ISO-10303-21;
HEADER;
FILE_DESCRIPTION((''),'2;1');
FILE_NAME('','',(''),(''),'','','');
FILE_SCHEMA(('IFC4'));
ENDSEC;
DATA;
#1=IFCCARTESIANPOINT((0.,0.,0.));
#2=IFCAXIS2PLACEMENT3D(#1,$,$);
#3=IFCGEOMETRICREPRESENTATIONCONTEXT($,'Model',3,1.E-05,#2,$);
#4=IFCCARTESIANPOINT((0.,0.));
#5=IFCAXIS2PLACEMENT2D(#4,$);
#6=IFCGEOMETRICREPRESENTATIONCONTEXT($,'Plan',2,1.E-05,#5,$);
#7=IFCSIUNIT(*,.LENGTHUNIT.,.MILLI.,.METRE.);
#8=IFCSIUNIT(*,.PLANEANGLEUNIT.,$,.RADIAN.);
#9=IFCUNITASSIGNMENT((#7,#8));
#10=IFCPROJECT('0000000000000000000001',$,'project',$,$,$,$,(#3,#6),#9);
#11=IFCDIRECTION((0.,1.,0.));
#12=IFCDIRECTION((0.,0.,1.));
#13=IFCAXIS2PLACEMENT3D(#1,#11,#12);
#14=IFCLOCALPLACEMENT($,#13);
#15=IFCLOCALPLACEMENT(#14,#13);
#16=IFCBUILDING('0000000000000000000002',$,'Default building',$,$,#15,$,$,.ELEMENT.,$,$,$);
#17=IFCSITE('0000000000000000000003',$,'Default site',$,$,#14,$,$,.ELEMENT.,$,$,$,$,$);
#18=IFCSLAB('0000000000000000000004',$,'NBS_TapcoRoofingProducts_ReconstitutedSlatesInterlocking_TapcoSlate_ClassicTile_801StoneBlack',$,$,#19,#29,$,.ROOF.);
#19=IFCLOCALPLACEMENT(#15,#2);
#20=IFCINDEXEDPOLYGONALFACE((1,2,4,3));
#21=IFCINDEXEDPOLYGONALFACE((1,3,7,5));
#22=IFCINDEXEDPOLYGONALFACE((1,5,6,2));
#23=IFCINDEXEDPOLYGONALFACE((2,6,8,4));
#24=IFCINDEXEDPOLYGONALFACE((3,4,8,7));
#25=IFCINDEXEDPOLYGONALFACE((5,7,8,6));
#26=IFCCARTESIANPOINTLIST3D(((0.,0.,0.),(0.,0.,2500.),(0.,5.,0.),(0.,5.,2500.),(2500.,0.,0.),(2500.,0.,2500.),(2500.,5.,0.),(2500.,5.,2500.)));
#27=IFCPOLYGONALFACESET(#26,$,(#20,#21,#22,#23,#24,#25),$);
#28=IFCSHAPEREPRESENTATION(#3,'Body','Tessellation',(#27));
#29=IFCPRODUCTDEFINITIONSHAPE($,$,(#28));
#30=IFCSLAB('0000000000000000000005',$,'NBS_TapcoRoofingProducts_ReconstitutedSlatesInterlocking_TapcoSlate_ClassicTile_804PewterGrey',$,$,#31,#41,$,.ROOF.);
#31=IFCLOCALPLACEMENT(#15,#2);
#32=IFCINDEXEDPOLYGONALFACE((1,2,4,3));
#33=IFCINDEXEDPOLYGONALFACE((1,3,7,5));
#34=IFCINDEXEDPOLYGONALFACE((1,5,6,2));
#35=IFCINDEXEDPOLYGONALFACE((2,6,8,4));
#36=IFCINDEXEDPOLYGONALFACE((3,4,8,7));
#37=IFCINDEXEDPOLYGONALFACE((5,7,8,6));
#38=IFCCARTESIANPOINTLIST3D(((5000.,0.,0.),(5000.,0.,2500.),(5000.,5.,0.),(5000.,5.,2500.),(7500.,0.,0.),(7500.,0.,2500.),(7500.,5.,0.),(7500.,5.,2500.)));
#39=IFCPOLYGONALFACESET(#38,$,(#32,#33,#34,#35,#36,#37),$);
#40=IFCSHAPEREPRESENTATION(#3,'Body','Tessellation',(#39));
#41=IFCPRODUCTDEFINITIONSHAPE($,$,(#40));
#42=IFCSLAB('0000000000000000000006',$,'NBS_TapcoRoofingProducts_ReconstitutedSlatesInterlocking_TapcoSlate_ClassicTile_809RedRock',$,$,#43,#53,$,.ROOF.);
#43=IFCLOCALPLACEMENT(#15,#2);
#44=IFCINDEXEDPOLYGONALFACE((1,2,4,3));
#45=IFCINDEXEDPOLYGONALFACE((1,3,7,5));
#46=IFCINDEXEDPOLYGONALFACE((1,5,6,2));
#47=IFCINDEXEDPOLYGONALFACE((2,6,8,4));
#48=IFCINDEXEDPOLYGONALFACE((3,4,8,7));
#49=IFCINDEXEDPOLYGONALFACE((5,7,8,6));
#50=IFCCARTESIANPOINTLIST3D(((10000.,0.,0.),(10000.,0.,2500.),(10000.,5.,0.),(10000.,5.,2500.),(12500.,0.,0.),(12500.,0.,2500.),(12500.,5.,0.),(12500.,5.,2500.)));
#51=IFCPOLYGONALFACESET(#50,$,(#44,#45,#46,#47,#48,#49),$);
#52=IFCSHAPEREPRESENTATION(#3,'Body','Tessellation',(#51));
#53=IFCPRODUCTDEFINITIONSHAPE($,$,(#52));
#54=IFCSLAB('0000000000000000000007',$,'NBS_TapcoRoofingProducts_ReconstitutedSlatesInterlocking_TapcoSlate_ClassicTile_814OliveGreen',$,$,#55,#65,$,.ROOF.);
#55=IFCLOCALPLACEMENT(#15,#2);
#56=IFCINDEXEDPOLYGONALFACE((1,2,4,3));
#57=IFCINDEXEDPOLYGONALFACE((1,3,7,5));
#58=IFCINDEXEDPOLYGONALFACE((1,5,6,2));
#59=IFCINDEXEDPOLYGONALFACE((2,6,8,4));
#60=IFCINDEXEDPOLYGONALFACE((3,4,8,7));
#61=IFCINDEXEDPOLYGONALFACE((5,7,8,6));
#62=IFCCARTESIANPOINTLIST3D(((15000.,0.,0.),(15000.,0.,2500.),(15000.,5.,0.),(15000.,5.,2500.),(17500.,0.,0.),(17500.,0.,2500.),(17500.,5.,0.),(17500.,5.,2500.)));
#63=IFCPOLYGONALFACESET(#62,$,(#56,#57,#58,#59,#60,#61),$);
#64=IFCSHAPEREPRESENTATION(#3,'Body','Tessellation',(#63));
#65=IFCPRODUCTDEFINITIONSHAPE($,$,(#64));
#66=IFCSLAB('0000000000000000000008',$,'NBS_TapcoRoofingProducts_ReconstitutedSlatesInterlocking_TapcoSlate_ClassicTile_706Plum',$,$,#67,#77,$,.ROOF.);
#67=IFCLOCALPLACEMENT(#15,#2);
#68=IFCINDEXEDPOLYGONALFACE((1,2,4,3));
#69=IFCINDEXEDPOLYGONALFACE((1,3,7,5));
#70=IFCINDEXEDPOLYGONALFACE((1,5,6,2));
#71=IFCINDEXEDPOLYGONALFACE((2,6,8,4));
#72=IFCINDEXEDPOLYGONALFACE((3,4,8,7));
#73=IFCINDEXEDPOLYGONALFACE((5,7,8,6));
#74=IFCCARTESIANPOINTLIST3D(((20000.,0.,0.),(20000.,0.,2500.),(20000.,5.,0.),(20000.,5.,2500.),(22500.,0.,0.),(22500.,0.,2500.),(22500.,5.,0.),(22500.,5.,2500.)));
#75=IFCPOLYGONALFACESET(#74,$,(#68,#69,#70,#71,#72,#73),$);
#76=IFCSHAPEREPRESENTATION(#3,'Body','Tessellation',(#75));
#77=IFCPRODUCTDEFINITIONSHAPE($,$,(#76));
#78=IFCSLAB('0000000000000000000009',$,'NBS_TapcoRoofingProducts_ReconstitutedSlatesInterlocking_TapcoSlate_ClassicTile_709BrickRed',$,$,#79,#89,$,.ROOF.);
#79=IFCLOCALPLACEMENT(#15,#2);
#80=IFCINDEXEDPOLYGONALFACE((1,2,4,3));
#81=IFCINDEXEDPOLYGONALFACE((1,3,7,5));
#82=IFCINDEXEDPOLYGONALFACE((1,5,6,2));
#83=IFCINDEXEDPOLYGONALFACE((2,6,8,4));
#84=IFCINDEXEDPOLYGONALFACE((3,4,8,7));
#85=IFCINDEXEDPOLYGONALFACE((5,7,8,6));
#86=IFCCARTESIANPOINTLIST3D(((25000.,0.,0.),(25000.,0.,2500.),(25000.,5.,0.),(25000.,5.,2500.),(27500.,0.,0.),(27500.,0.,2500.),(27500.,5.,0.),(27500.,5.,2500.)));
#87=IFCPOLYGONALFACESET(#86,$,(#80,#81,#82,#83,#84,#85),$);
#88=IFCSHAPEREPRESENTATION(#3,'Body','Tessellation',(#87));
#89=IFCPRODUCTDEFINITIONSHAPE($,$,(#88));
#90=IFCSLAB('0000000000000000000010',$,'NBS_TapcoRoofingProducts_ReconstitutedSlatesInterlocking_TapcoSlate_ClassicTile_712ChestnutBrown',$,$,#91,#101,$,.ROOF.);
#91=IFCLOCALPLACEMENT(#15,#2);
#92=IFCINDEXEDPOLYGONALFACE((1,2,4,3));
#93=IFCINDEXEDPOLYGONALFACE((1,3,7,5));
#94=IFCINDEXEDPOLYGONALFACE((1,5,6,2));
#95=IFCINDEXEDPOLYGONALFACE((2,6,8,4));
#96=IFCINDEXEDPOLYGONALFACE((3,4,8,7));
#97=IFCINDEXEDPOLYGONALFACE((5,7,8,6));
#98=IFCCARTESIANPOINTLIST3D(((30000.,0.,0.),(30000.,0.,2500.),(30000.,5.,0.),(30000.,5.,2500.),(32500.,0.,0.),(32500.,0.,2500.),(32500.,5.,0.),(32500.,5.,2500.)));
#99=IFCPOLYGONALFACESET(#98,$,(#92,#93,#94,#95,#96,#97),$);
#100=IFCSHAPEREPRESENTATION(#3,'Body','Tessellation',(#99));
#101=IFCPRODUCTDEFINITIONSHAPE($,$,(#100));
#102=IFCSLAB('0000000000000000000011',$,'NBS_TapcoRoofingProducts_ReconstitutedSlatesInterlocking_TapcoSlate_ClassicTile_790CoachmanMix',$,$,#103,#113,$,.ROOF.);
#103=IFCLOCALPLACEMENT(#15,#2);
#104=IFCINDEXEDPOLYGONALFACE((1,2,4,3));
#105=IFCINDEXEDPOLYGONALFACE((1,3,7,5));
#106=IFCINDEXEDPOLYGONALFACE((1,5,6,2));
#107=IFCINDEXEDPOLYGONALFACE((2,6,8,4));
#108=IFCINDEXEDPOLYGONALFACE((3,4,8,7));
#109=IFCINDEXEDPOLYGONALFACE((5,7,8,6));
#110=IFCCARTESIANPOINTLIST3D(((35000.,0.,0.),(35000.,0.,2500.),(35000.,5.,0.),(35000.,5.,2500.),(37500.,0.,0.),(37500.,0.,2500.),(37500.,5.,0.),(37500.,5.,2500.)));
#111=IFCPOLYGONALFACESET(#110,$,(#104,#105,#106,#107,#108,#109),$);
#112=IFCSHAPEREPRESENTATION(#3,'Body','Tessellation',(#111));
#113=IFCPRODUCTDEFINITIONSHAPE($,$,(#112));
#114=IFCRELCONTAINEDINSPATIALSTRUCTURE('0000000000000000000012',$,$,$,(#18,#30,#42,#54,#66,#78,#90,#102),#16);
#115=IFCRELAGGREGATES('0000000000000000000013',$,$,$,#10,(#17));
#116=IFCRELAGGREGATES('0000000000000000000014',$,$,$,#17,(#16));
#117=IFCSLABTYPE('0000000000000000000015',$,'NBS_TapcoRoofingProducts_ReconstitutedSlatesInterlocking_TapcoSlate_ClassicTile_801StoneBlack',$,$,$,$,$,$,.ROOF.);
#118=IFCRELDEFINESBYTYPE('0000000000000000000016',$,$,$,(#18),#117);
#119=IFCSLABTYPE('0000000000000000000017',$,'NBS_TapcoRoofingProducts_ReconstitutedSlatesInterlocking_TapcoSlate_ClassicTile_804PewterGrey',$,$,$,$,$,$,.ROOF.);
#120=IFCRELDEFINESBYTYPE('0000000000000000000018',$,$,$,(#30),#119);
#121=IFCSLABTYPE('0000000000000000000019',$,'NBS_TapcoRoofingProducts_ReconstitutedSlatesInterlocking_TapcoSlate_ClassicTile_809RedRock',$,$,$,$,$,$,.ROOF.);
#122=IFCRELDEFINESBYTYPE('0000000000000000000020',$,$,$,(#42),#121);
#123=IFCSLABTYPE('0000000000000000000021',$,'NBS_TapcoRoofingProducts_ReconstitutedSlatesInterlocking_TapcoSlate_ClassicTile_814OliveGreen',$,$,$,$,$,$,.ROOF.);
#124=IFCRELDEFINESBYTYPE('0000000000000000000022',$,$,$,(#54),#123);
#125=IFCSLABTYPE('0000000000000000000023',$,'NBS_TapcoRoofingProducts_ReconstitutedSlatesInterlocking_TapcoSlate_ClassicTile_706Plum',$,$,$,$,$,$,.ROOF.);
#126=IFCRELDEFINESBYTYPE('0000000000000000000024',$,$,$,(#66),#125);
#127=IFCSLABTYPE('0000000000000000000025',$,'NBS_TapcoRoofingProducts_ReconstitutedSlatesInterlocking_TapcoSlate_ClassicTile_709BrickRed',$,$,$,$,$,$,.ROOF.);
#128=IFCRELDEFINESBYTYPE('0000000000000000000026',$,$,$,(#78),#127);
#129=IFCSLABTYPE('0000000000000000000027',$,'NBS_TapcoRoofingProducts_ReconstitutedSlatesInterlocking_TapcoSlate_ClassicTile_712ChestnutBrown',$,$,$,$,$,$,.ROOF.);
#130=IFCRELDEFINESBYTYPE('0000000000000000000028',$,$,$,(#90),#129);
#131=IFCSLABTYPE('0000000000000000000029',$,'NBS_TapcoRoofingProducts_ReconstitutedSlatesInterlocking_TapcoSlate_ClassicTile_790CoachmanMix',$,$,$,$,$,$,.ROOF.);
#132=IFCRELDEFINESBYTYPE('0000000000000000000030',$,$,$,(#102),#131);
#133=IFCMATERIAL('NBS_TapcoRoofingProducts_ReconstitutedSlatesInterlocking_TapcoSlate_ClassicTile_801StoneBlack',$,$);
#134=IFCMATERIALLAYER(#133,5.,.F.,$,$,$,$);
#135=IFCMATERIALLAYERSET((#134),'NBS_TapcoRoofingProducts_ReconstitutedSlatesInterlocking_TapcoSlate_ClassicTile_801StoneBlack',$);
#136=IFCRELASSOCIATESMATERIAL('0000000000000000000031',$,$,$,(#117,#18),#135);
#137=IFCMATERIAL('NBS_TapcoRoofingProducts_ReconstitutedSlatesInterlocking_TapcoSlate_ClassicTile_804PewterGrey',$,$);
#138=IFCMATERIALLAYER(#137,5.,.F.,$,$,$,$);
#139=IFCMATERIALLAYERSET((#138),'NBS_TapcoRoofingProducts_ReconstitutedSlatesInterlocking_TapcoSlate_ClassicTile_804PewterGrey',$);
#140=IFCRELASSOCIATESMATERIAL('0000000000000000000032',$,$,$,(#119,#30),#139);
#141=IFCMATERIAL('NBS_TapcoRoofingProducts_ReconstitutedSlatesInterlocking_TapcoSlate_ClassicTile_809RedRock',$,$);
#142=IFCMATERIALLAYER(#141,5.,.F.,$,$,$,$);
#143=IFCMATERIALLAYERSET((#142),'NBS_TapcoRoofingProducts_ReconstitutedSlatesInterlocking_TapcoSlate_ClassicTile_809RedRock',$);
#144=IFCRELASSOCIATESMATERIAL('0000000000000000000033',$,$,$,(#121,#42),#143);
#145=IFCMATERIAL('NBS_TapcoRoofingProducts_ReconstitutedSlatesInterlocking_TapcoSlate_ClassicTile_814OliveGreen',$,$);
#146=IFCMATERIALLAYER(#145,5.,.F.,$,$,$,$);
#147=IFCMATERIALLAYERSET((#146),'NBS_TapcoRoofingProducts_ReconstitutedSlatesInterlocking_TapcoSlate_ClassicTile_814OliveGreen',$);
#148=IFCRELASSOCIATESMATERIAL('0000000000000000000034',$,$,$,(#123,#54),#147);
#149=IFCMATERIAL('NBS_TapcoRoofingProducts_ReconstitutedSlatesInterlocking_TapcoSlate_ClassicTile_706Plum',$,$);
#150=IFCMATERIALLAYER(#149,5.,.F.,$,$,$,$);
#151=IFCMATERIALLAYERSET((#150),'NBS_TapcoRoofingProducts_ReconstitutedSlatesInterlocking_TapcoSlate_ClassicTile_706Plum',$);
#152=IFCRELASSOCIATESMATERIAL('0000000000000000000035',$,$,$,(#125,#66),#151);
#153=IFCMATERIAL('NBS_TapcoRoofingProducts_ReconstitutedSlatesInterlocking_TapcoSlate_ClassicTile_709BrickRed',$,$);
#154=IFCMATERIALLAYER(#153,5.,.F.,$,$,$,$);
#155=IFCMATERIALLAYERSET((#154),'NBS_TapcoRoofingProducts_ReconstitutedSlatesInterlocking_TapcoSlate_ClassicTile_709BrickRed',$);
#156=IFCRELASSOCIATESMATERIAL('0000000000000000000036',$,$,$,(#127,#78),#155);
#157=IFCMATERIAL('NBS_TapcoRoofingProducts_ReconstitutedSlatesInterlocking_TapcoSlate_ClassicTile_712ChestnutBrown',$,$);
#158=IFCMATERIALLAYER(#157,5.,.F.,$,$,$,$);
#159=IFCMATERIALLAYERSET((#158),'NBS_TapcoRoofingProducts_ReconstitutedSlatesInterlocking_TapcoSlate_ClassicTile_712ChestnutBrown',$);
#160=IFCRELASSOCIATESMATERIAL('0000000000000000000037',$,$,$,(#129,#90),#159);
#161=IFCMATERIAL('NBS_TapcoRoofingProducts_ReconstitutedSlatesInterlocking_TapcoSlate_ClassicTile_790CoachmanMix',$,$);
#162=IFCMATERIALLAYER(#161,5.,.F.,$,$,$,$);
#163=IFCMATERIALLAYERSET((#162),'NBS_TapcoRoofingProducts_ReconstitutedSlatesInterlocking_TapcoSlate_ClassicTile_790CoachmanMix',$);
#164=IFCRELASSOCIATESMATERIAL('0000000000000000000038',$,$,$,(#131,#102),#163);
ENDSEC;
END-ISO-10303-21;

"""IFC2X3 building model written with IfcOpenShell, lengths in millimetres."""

from ifc_helpers import new_model, si_unit, frame, frame_2d, origin, origin_with_axes, origin_2d, place, context, project, spatial, rectangle, extrude, material, layer, layer_set, layer_usage, type_object, element, save


model = new_model("IFC2X3")

# Units and contexts
model_context = context("Model", 3, precision=1e-05, world=origin())
plan_context = context("Plan", 2, precision=1e-05, world=origin_2d())
ifc_project = project(units=[si_unit("LENGTHUNIT", "METRE", prefix="MILLI"), si_unit("PLANEANGLEUNIT", "RADIAN")], contexts=[model_context, plan_context])

# Site, building
site_placement = place(None, frame((0.0, 0.0, 0.0), z_axis=(0.0, 1.0, 0.0), x_axis=(0.0, 0.0, 1.0)))
site = spatial("IfcSite", under=ifc_project, at=site_placement, Name="Default site", CompositionType="ELEMENT")
building_placement = place(site_placement, frame((0.0, 0.0, 0.0), z_axis=(0.0, 1.0, 0.0), x_axis=(0.0, 0.0, 1.0)))
building = spatial("IfcBuilding", under=site, at=building_placement, Name="Default building", CompositionType="ELEMENT")

# Slabs
ifc_material_1 = material(Name="NBS_TapcoRoofingProducts_ReconstitutedSlatesInterlocking_TapcoSlate_ClassicTile_801StoneBlack")
ifc_layer_1 = layer(ifc_material_1, 5.0, ventilated=False)
ifc_layer_set_1 = layer_set([ifc_layer_1], Name="NBS_TapcoRoofingProducts_ReconstitutedSlatesInterlocking_TapcoSlate_ClassicTile_801StoneBlack")
ifc_layer_usage_1 = layer_usage(ifc_layer_set_1, "AXIS3", "NEGATIVE", 0.0)
slab_type_1 = type_object("IfcSlabType", Name="NBS_TapcoRoofingProducts_ReconstitutedSlatesInterlocking_TapcoSlate_ClassicTile_801StoneBlack", PredefinedType="ROOF", material=ifc_layer_set_1)
slab_1_placement = place(None, origin())
element("IfcSlab", 1, at=slab_1_placement, inside=building, type_object=slab_type_1, material=ifc_layer_usage_1, Name="NBS_TapcoRoofingProducts_ReconstitutedSlatesInterlocking_TapcoSlate_ClassicTile_801StoneBlack", PredefinedType="ROOF", context=model_context, shape_type="SweptSolid", body=[
    extrude(rectangle(XDim=2500.0, YDim=2500.0, at=frame_2d((1250.0, 1250.0))), origin_with_axes(), (0.0, 0.0, 1.0), 5.0),
])
ifc_material_2 = material(Name="NBS_TapcoRoofingProducts_ReconstitutedSlatesInterlocking_TapcoSlate_ClassicTile_804PewterGrey")
ifc_layer_2 = layer(ifc_material_2, 5.0, ventilated=False)
ifc_layer_set_2 = layer_set([ifc_layer_2], Name="NBS_TapcoRoofingProducts_ReconstitutedSlatesInterlocking_TapcoSlate_ClassicTile_804PewterGrey")
ifc_layer_usage_2 = layer_usage(ifc_layer_set_2, "AXIS3", "NEGATIVE", 0.0)
slab_type_2 = type_object("IfcSlabType", Name="NBS_TapcoRoofingProducts_ReconstitutedSlatesInterlocking_TapcoSlate_ClassicTile_804PewterGrey", PredefinedType="ROOF", material=ifc_layer_set_2)
slab_2_placement = place(None, frame((0.0, 5000.0, 0.0)))
element("IfcSlab", 2, at=slab_2_placement, inside=building, type_object=slab_type_2, material=ifc_layer_usage_2, Name="NBS_TapcoRoofingProducts_ReconstitutedSlatesInterlocking_TapcoSlate_ClassicTile_804PewterGrey", PredefinedType="ROOF", context=model_context, shape_type="SweptSolid", body=[
    extrude(rectangle(XDim=2500.0, YDim=2500.0, at=frame_2d((1250.0, 1250.0))), origin_with_axes(), (0.0, 0.0, 1.0), 5.0),
])
ifc_material_3 = material(Name="NBS_TapcoRoofingProducts_ReconstitutedSlatesInterlocking_TapcoSlate_ClassicTile_809RedRock")
ifc_layer_3 = layer(ifc_material_3, 5.0, ventilated=False)
ifc_layer_set_3 = layer_set([ifc_layer_3], Name="NBS_TapcoRoofingProducts_ReconstitutedSlatesInterlocking_TapcoSlate_ClassicTile_809RedRock")
ifc_layer_usage_3 = layer_usage(ifc_layer_set_3, "AXIS3", "NEGATIVE", 0.0)
slab_type_3 = type_object("IfcSlabType", Name="NBS_TapcoRoofingProducts_ReconstitutedSlatesInterlocking_TapcoSlate_ClassicTile_809RedRock", PredefinedType="ROOF", material=ifc_layer_set_3)
slab_3_placement = place(None, frame((0.0, 10000.0, 0.0)))
element("IfcSlab", 3, at=slab_3_placement, inside=building, type_object=slab_type_3, material=ifc_layer_usage_3, Name="NBS_TapcoRoofingProducts_ReconstitutedSlatesInterlocking_TapcoSlate_ClassicTile_809RedRock", PredefinedType="ROOF", context=model_context, shape_type="SweptSolid", body=[
    extrude(rectangle(XDim=2500.0, YDim=2500.0, at=frame_2d((1250.0, 1250.0))), origin_with_axes(), (0.0, 0.0, 1.0), 5.0),
])
ifc_material_4 = material(Name="NBS_TapcoRoofingProducts_ReconstitutedSlatesInterlocking_TapcoSlate_ClassicTile_814OliveGreen")
ifc_layer_4 = layer(ifc_material_4, 5.0, ventilated=False)
ifc_layer_set_4 = layer_set([ifc_layer_4], Name="NBS_TapcoRoofingProducts_ReconstitutedSlatesInterlocking_TapcoSlate_ClassicTile_814OliveGreen")
ifc_layer_usage_4 = layer_usage(ifc_layer_set_4, "AXIS3", "NEGATIVE", 0.0)
slab_type_4 = type_object("IfcSlabType", Name="NBS_TapcoRoofingProducts_ReconstitutedSlatesInterlocking_TapcoSlate_ClassicTile_814OliveGreen", PredefinedType="ROOF", material=ifc_layer_set_4)
slab_4_placement = place(None, frame((0.0, 15000.0, 0.0)))
element("IfcSlab", 4, at=slab_4_placement, inside=building, type_object=slab_type_4, material=ifc_layer_usage_4, Name="NBS_TapcoRoofingProducts_ReconstitutedSlatesInterlocking_TapcoSlate_ClassicTile_814OliveGreen", PredefinedType="ROOF", context=model_context, shape_type="SweptSolid", body=[
    extrude(rectangle(XDim=2500.0, YDim=2500.0, at=frame_2d((1250.0, 1250.0))), origin_with_axes(), (0.0, 0.0, 1.0), 5.0),
])
ifc_material_5 = material(Name="NBS_TapcoRoofingProducts_ReconstitutedSlatesInterlocking_TapcoSlate_ClassicTile_706Plum")
ifc_layer_5 = layer(ifc_material_5, 5.0, ventilated=False)
ifc_layer_set_5 = layer_set([ifc_layer_5], Name="NBS_TapcoRoofingProducts_ReconstitutedSlatesInterlocking_TapcoSlate_ClassicTile_706Plum")
ifc_layer_usage_5 = layer_usage(ifc_layer_set_5, "AXIS3", "NEGATIVE", 0.0)
slab_type_5 = type_object("IfcSlabType", Name="NBS_TapcoRoofingProducts_ReconstitutedSlatesInterlocking_TapcoSlate_ClassicTile_706Plum", PredefinedType="ROOF", material=ifc_layer_set_5)
slab_5_placement = place(None, frame((0.0, 20000.0, 0.0)))
element("IfcSlab", 5, at=slab_5_placement, inside=building, type_object=slab_type_5, material=ifc_layer_usage_5, Name="NBS_TapcoRoofingProducts_ReconstitutedSlatesInterlocking_TapcoSlate_ClassicTile_706Plum", PredefinedType="ROOF", context=model_context, shape_type="SweptSolid", body=[
    extrude(rectangle(XDim=2500.0, YDim=2500.0, at=frame_2d((1250.0, 1250.0))), origin_with_axes(), (0.0, 0.0, 1.0), 5.0),
])
ifc_material_6 = material(Name="NBS_TapcoRoofingProducts_ReconstitutedSlatesInterlocking_TapcoSlate_ClassicTile_709BrickRed")
ifc_layer_6 = layer(ifc_material_6, 5.0, ventilated=False)
ifc_layer_set_6 = layer_set([ifc_layer_6], Name="NBS_TapcoRoofingProducts_ReconstitutedSlatesInterlocking_TapcoSlate_ClassicTile_709BrickRed")
ifc_layer_usage_6 = layer_usage(ifc_layer_set_6, "AXIS3", "NEGATIVE", 0.0)
slab_type_6 = type_object("IfcSlabType", Name="NBS_TapcoRoofingProducts_ReconstitutedSlatesInterlocking_TapcoSlate_ClassicTile_709BrickRed", PredefinedType="ROOF", material=ifc_layer_set_6)
slab_6_placement = place(None, frame((0.0, 25000.0, 0.0)))
element("IfcSlab", 6, at=slab_6_placement, inside=building, type_object=slab_type_6, material=ifc_layer_usage_6, Name="NBS_TapcoRoofingProducts_ReconstitutedSlatesInterlocking_TapcoSlate_ClassicTile_709BrickRed", PredefinedType="ROOF", context=model_context, shape_type="SweptSolid", body=[
    extrude(rectangle(XDim=2500.0, YDim=2500.0, at=frame_2d((1250.0, 1250.0))), origin_with_axes(), (0.0, 0.0, 1.0), 5.0),
])
ifc_material_7 = material(Name="NBS_TapcoRoofingProducts_ReconstitutedSlatesInterlocking_TapcoSlate_ClassicTile_712ChestnutBrown")
ifc_layer_7 = layer(ifc_material_7, 5.0, ventilated=False)
ifc_layer_set_7 = layer_set([ifc_layer_7], Name="NBS_TapcoRoofingProducts_ReconstitutedSlatesInterlocking_TapcoSlate_ClassicTile_712ChestnutBrown")
ifc_layer_usage_7 = layer_usage(ifc_layer_set_7, "AXIS3", "NEGATIVE", 0.0)
slab_type_7 = type_object("IfcSlabType", Name="NBS_TapcoRoofingProducts_ReconstitutedSlatesInterlocking_TapcoSlate_ClassicTile_712ChestnutBrown", PredefinedType="ROOF", material=ifc_layer_set_7)
slab_7_placement = place(None, frame((0.0, 30000.0, 0.0)))
element("IfcSlab", 7, at=slab_7_placement, inside=building, type_object=slab_type_7, material=ifc_layer_usage_7, Name="NBS_TapcoRoofingProducts_ReconstitutedSlatesInterlocking_TapcoSlate_ClassicTile_712ChestnutBrown", PredefinedType="ROOF", context=model_context, shape_type="SweptSolid", body=[
    extrude(rectangle(XDim=2500.0, YDim=2500.0, at=frame_2d((1250.0, 1250.0))), origin_with_axes(), (0.0, 0.0, 1.0), 5.0),
])
ifc_material_8 = material(Name="NBS_TapcoRoofingProducts_ReconstitutedSlatesInterlocking_TapcoSlate_ClassicTile_790CoachmanMix")
ifc_layer_8 = layer(ifc_material_8, 5.0, ventilated=False)
ifc_layer_set_8 = layer_set([ifc_layer_8], Name="NBS_TapcoRoofingProducts_ReconstitutedSlatesInterlocking_TapcoSlate_ClassicTile_790CoachmanMix")
ifc_layer_usage_8 = layer_usage(ifc_layer_set_8, "AXIS3", "NEGATIVE", 0.0)
slab_type_8 = type_object("IfcSlabType", Name="NBS_TapcoRoofingProducts_ReconstitutedSlatesInterlocking_TapcoSlate_ClassicTile_790CoachmanMix", PredefinedType="ROOF", material=ifc_layer_set_8)
slab_8_placement = place(None, frame((0.0, 35000.0, 0.0)))
element("IfcSlab", 8, at=slab_8_placement, inside=building, type_object=slab_type_8, material=ifc_layer_usage_8, Name="NBS_TapcoRoofingProducts_ReconstitutedSlatesInterlocking_TapcoSlate_ClassicTile_790CoachmanMix", PredefinedType="ROOF", context=model_context, shape_type="SweptSolid", body=[
    extrude(rectangle(XDim=2500.0, YDim=2500.0, at=frame_2d((1250.0, 1250.0))), origin_with_axes(), (0.0, 0.0, 1.0), 5.0),
])

save(model, "model.ifc")
